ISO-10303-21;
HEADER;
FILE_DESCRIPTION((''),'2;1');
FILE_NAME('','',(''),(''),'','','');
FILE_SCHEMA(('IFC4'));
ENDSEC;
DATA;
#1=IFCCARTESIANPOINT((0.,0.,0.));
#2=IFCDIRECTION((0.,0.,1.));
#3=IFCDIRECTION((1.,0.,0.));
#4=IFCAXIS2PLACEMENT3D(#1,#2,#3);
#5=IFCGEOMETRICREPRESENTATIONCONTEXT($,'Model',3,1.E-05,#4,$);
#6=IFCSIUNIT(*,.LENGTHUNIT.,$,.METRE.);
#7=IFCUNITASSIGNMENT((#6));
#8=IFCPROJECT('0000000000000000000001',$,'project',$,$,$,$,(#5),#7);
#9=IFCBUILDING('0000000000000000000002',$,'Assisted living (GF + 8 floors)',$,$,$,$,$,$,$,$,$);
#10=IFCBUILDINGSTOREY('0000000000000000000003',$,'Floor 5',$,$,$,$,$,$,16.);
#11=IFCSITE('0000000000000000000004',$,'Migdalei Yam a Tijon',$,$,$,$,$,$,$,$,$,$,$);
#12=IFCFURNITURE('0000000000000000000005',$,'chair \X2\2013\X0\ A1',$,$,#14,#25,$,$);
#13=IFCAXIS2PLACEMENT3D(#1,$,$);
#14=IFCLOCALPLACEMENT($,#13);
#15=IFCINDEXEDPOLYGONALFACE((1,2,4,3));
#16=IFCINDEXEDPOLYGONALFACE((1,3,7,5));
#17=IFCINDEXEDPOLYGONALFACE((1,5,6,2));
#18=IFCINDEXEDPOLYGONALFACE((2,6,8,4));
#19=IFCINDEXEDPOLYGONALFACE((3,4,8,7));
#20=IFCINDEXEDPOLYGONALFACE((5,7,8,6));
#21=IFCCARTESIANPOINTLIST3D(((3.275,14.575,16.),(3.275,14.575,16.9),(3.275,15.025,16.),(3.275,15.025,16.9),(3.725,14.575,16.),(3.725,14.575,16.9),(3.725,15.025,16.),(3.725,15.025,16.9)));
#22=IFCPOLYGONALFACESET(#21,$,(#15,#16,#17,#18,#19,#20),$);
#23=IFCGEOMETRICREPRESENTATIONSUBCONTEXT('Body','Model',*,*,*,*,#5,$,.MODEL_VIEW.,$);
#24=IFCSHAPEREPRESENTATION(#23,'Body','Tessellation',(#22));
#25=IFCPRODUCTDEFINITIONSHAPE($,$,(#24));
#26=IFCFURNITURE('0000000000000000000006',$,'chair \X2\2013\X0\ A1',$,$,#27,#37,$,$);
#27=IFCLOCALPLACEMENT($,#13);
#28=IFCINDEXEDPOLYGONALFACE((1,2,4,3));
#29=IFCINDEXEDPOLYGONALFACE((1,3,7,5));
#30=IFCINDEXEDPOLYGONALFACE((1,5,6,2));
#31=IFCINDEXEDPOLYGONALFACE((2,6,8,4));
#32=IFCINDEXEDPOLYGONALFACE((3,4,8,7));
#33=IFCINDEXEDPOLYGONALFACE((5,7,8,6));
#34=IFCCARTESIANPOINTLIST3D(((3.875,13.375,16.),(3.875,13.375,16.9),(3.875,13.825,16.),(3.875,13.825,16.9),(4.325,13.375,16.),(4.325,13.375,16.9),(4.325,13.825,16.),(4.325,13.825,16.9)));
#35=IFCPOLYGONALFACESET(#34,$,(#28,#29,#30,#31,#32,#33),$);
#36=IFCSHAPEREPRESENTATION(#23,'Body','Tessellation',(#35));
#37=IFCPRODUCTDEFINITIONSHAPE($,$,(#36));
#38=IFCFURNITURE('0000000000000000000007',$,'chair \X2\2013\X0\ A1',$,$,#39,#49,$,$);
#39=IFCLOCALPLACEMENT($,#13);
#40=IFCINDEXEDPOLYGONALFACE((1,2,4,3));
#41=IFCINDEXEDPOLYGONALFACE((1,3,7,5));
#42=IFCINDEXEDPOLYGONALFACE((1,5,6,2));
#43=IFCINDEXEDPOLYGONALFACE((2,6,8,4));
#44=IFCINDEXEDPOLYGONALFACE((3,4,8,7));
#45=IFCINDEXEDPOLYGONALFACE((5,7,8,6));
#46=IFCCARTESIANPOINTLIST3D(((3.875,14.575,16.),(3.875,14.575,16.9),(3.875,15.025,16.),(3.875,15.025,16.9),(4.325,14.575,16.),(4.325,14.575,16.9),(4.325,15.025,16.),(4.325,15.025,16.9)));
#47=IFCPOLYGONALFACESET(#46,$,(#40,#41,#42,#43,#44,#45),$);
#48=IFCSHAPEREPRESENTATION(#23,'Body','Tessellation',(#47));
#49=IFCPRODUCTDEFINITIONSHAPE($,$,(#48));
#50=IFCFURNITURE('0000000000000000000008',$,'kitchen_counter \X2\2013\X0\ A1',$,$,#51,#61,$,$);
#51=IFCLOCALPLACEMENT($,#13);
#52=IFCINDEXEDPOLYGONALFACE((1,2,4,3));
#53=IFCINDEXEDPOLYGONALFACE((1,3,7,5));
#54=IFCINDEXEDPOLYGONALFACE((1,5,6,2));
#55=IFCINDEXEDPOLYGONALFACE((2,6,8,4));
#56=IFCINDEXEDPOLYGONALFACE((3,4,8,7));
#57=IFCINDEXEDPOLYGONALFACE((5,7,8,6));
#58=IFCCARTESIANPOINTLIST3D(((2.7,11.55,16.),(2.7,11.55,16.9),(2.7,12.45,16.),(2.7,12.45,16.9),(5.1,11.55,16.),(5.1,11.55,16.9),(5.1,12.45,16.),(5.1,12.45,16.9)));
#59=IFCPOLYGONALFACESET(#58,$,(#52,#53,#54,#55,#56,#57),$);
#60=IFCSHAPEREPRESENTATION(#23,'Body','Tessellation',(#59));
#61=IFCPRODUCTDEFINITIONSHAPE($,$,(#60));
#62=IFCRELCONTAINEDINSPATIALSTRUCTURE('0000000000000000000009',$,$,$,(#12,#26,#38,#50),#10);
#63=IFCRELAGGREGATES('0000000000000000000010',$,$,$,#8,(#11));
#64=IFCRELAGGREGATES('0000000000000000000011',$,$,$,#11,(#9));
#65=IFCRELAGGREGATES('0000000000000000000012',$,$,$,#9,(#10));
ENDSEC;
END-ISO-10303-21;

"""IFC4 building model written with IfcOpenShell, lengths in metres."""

from ifc_helpers import new_model, si_unit, frame, origin_with_axes, context, subcontext, project, spatial, line, indexed_curve, outline, extrude, element, save


model = new_model("IFC4")

# Units and contexts
model_context = context("Model", 3, precision=1e-05, world=origin_with_axes())
body_context = subcontext(model_context, "Body", "Model", "MODEL_VIEW")
ifc_project = project(units=[si_unit("LENGTHUNIT", "METRE")], contexts=[model_context])

# Site, building, storey
site = spatial("IfcSite", under=ifc_project, Name="Migdalei Yam a Tijon")
building = spatial("IfcBuilding", under=site, Name="Assisted living (GF + 8 floors)")
storey = spatial("IfcBuildingStorey", under=building, Name="Floor 5", Elevation=16.0)

# Furniture
element("IfcFurniture", 1, inside=storey, Name="chair – A1", context=body_context, shape_type="SweptSolid", body=[
    extrude(outline(indexed_curve([(0.0, 0.0), (0.45, 0.0), (0.45, 0.45), (0.0, 0.45)], segments=[line(1, 2, 3, 4, 1)])), frame((3.275, 14.575, 16.0), z_axis=(0.0, 0.0, 1.0), x_axis=(1.0, 0.0, 0.0)), (0.0, 0.0, 1.0), 0.9),
])
element("IfcFurniture", 2, inside=storey, Name="chair – A1", context=body_context, shape_type="SweptSolid", body=[
    extrude(outline(indexed_curve([(0.0, 0.0), (0.45, 0.0), (0.45, 0.45), (0.0, 0.45)], segments=[line(1, 2, 3, 4, 1)])), frame((3.875, 13.375, 16.0), z_axis=(0.0, 0.0, 1.0), x_axis=(1.0, 0.0, 0.0)), (0.0, 0.0, 1.0), 0.9),
])
element("IfcFurniture", 3, inside=storey, Name="chair – A1", context=body_context, shape_type="SweptSolid", body=[
    extrude(outline(indexed_curve([(0.0, 0.0), (0.45, 0.0), (0.45, 0.45), (0.0, 0.45)], segments=[line(1, 2, 3, 4, 1)])), frame((3.875, 14.575, 16.0), z_axis=(0.0, 0.0, 1.0), x_axis=(1.0, 0.0, 0.0)), (0.0, 0.0, 1.0), 0.9),
])
element("IfcFurniture", 4, inside=storey, Name="kitchen_counter – A1", context=body_context, shape_type="SweptSolid", body=[
    extrude(outline(indexed_curve([(0.0, 0.0), (2.4, 0.0), (2.4, 0.9), (0.0, 0.9)], segments=[line(1, 2, 3, 4, 1)])), frame((2.7, 11.55, 16.0), z_axis=(0.0, 0.0, 1.0), x_axis=(1.0, 0.0, 0.0)), (0.0, 0.0, 1.0), 0.9),
])

save(model, "model.ifc")
